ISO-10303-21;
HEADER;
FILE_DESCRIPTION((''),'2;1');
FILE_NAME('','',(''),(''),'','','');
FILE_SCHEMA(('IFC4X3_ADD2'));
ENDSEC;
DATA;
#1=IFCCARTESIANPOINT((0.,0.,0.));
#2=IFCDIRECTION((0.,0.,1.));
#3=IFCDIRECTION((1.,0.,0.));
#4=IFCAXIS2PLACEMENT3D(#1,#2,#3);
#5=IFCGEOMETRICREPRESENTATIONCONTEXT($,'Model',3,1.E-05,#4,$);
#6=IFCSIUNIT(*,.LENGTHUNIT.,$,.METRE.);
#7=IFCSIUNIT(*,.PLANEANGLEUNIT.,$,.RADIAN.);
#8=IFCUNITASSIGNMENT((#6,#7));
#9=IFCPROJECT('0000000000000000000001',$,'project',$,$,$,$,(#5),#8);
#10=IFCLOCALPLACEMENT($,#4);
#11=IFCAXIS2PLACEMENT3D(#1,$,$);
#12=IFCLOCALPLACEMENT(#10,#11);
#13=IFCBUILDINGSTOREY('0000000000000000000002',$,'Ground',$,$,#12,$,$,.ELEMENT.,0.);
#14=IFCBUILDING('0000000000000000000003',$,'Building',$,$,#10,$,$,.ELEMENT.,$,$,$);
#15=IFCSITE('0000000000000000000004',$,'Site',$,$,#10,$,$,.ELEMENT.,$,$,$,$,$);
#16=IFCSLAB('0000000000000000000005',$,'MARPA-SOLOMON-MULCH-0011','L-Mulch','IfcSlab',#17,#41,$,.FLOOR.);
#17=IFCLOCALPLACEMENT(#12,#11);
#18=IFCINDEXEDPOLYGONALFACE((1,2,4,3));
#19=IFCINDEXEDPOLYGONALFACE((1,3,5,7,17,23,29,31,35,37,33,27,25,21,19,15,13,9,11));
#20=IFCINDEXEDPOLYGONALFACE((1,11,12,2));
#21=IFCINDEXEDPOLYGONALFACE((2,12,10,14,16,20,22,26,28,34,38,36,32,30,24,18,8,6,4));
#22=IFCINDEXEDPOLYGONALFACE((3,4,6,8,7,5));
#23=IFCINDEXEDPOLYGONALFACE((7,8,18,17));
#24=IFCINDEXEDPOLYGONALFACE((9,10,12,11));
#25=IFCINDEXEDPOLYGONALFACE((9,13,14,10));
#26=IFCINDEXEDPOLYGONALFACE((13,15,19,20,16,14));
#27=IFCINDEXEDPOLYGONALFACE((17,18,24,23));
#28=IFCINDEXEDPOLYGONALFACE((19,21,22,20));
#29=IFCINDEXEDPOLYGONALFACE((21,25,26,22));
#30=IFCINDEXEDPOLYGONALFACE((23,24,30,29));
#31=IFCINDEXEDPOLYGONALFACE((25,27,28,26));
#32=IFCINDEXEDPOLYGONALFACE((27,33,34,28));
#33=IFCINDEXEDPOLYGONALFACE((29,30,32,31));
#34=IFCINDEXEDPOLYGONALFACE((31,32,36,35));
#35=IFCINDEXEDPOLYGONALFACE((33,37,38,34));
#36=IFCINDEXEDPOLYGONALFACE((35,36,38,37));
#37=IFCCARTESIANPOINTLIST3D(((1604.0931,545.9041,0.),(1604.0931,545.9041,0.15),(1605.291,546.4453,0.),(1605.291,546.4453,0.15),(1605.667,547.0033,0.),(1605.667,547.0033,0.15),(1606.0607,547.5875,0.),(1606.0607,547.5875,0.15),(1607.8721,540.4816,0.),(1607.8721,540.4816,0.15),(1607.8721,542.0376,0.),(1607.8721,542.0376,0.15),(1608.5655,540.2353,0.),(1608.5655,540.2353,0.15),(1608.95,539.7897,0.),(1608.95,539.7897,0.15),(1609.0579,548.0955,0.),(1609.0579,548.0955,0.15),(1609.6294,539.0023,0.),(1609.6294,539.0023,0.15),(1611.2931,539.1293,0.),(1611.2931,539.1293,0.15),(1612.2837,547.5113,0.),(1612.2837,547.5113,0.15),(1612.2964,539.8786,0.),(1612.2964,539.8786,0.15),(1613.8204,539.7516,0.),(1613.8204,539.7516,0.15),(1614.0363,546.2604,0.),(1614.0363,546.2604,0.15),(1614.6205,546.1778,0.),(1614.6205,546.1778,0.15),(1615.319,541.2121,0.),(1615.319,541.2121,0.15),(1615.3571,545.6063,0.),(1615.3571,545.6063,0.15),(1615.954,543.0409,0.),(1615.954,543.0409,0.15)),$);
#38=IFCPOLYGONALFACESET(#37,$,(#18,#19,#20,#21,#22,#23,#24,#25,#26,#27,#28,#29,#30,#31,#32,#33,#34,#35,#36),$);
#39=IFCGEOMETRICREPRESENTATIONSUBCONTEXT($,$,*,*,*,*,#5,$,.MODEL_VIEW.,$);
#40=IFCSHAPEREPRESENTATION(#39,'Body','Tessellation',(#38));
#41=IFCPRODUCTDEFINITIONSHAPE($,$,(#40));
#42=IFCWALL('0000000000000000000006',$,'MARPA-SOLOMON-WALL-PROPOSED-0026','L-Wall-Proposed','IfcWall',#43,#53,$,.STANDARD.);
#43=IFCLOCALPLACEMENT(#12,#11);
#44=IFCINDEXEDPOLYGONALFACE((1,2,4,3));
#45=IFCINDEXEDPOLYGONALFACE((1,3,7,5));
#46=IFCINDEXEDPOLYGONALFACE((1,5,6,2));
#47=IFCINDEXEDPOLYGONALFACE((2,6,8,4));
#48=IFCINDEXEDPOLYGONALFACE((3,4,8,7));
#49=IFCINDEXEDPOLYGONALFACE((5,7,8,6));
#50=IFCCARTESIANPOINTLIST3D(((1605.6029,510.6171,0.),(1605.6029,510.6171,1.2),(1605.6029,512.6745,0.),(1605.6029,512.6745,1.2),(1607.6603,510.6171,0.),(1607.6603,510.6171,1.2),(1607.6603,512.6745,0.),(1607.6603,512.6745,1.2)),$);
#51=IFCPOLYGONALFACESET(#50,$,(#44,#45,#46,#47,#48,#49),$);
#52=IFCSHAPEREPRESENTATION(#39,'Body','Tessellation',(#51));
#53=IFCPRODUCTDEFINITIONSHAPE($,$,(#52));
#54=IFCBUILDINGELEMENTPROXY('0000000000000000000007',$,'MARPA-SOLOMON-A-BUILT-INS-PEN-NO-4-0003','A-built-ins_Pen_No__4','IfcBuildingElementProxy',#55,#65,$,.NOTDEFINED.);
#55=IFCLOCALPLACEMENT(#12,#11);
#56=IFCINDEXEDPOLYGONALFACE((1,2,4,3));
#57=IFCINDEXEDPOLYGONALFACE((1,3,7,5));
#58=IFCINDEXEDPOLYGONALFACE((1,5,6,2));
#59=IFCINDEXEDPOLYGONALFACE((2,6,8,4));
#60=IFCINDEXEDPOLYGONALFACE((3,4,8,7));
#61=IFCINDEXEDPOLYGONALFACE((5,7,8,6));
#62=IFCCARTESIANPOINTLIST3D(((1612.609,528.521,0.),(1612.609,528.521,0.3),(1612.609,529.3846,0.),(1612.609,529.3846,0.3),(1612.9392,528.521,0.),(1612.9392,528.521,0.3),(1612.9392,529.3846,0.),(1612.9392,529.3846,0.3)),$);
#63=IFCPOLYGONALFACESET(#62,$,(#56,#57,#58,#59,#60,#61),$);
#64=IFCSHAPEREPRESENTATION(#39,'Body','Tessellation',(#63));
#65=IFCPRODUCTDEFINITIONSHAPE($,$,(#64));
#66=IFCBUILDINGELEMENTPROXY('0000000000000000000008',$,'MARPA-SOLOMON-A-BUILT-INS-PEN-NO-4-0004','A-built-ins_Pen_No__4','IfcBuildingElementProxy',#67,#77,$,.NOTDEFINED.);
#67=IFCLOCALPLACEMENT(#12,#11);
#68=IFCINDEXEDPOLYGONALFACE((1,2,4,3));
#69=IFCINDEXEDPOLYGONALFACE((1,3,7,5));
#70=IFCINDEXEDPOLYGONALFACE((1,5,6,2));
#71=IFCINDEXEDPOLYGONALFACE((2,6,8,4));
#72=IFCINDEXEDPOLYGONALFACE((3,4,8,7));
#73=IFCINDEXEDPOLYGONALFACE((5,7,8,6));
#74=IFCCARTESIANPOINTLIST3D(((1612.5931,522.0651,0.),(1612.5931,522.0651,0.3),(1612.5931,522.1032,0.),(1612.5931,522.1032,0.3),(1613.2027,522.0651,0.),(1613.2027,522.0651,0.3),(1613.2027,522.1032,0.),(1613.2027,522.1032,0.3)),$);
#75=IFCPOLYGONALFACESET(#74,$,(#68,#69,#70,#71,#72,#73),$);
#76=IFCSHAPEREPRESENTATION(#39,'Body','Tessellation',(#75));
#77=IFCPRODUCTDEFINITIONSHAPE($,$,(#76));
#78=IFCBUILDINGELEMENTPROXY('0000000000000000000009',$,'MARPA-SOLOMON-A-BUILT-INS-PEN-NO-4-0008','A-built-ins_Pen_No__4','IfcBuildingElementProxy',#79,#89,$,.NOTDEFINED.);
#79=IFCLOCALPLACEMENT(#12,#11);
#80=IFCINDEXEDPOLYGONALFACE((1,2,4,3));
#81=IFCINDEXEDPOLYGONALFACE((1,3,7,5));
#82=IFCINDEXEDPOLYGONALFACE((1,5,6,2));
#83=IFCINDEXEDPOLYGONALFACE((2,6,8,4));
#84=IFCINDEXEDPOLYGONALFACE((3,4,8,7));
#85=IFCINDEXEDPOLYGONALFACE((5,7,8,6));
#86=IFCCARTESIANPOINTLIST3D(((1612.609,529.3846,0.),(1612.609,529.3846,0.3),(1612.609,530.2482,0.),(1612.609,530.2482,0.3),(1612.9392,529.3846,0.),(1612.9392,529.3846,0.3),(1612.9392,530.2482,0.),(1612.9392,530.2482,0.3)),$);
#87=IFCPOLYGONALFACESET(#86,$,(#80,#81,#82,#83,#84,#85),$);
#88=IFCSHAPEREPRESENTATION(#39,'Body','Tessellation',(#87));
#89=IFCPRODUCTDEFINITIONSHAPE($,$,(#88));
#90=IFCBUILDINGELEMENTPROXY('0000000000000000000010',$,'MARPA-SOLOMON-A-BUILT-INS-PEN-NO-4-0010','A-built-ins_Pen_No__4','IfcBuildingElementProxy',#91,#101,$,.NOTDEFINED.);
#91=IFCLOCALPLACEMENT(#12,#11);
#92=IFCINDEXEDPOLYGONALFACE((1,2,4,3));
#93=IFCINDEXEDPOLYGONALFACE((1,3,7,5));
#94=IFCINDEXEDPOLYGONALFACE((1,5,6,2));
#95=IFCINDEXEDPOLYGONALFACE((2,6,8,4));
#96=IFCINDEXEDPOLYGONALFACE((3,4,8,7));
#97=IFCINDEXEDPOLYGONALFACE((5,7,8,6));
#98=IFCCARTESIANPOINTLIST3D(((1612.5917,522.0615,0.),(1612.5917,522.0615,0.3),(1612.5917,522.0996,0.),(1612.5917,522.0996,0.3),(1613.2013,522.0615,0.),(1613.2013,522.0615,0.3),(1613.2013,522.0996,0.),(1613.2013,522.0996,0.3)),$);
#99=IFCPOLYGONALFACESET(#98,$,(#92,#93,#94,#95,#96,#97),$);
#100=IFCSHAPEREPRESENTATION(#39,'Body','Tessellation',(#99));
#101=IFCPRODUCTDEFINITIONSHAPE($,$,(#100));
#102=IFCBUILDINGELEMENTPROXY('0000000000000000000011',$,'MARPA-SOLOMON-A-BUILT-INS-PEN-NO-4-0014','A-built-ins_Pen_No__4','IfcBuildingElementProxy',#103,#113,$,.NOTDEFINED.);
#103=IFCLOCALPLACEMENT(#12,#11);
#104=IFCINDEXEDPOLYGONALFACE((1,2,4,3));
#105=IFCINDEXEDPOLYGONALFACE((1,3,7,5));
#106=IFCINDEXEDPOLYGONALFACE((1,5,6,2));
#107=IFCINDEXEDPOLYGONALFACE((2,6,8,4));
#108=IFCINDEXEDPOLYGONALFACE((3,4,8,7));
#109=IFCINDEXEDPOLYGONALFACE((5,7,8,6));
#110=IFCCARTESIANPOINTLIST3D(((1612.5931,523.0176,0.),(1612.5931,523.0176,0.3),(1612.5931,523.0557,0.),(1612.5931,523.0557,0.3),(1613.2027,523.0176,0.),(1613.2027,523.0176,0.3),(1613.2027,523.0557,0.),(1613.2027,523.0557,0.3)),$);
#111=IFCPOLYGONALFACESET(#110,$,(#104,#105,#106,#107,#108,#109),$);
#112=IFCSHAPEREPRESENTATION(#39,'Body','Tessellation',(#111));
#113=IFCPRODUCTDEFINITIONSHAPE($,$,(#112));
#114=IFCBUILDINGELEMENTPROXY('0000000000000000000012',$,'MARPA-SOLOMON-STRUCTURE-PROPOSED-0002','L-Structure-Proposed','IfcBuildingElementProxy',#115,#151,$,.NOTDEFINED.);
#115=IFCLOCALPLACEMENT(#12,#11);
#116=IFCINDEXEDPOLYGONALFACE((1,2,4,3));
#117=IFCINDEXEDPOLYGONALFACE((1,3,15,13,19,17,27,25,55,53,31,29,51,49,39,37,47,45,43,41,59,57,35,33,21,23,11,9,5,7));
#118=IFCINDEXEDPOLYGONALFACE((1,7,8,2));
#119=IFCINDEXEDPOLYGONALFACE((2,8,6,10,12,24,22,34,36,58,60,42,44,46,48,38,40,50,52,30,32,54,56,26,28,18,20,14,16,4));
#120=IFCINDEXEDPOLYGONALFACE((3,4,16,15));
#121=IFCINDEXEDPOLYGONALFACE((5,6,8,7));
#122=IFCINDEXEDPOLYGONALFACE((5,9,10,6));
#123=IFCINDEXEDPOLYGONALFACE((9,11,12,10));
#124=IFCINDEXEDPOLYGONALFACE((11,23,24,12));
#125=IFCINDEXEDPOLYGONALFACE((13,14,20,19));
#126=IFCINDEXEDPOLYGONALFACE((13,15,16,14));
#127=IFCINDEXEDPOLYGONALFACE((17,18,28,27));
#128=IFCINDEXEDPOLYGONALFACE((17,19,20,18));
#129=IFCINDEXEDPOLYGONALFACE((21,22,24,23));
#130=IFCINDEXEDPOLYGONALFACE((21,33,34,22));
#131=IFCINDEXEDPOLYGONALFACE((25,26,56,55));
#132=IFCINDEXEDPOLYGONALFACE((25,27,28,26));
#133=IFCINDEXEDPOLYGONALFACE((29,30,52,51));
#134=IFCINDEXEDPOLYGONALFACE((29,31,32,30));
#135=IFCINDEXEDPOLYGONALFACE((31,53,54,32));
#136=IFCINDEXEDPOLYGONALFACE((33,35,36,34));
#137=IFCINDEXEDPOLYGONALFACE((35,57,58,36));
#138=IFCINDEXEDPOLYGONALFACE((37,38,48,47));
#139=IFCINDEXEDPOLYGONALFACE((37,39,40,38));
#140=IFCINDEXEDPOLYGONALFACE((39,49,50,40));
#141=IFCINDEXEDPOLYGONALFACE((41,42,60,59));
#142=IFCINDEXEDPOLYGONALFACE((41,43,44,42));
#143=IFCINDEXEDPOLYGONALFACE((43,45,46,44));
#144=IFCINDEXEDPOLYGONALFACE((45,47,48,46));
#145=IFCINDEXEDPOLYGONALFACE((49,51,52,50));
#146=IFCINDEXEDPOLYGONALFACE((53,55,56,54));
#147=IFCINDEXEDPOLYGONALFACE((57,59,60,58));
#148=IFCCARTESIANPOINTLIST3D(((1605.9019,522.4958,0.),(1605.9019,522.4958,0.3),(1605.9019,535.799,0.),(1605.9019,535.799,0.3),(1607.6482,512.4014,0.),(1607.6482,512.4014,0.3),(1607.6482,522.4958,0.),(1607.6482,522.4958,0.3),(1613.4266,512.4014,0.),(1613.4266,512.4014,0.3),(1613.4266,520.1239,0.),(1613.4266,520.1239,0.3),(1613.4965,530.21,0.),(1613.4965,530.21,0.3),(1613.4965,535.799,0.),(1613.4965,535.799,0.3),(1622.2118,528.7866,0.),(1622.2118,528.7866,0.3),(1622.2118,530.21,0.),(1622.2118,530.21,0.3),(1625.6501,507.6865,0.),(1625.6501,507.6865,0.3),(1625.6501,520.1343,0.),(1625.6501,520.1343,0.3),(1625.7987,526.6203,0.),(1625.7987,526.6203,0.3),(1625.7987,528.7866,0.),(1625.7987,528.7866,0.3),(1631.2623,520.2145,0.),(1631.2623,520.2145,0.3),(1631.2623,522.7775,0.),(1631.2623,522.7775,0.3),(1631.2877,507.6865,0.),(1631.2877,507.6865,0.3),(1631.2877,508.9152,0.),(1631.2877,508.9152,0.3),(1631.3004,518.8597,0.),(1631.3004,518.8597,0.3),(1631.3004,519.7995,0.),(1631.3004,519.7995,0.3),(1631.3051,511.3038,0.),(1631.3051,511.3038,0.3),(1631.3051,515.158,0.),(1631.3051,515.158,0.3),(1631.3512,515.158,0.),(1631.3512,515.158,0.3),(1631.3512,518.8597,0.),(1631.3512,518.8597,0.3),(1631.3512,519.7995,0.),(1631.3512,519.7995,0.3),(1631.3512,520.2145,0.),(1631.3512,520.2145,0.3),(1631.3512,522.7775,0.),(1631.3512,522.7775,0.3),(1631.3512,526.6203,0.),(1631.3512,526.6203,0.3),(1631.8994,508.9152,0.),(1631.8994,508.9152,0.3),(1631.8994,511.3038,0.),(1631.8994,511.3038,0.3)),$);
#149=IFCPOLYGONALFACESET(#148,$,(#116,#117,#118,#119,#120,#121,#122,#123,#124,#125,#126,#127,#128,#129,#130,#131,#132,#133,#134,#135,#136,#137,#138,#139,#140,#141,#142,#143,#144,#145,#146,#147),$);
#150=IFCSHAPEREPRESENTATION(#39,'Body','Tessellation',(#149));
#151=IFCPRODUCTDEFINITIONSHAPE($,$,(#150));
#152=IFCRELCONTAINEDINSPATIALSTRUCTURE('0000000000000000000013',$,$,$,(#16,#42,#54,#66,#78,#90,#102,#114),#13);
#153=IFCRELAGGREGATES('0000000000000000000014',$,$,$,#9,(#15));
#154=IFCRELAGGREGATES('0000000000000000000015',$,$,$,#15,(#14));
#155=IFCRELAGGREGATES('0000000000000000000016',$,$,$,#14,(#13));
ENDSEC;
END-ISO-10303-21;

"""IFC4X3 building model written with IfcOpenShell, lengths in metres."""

from ifc_helpers import new_model, si_unit, frame, frame_2d, origin, origin_with_axes, place, context, subcontext, project, spatial, polyline, rectangle, outline, extrude, element, save


model = new_model("IFC4X3")

# Units and contexts
model_context = context("Model", 3, precision=1e-05, world=origin_with_axes())
sub_context = subcontext(model_context, None, None, "MODEL_VIEW")
ifc_project = project(units=[si_unit("LENGTHUNIT", "METRE"), si_unit("PLANEANGLEUNIT", "RADIAN")], contexts=[model_context])

# Site, building, storey
placement = place(None, origin_with_axes())
site = spatial("IfcSite", under=ifc_project, at=placement, Name="Site", CompositionType="ELEMENT")
building = spatial("IfcBuilding", under=site, at=placement, Name="Building", CompositionType="ELEMENT")
storey_placement = place(placement, origin())
storey = spatial("IfcBuildingStorey", under=building, at=storey_placement, Name="Ground", CompositionType="ELEMENT", Elevation=0.0)

# Slab
slab_1_placement = place(storey_placement, frame((1604.0931, 539.0023, 0.0)))
element("IfcSlab", 1, at=slab_1_placement, inside=storey, Name="MARPA-SOLOMON-MULCH-0011", Description="L-Mulch", ObjectType="IfcSlab", PredefinedType="FLOOR", context=sub_context, shape_type="SweptSolid", body=[
    extrude(outline(polyline([(1.9676, 8.5852), (1.5739, 8.001), (1.1979, 7.443), (0.0, 6.9017), (3.779, 3.0353), (3.779, 1.4792), (4.4724, 1.2329), (4.8569, 0.7874), (5.5363, 0.0), (7.2, 0.127), (8.2033, 0.8763), (9.7273, 0.7493), (11.2259, 2.2098), (11.8609, 4.0386), (11.264, 6.604), (10.5274, 7.1755), (9.9432, 7.2581), (8.1906, 8.509), (4.9648, 9.0932), (1.9676, 8.5852)])), origin(), (0.0, 0.0, 1.0), 0.15),
])

# Wall
wall_placement = place(storey_placement, frame((1606.6316, 510.6171, 0.0), x_axis=(0.0, 1.0, 0.0)))
element("IfcWall", 2, at=wall_placement, inside=storey, Name="MARPA-SOLOMON-WALL-PROPOSED-0026", Description="L-Wall-Proposed", ObjectType="IfcWall", PredefinedType="STANDARD", context=sub_context, shape_type="SweptSolid", body=[
    extrude(rectangle(XDim=2.0574, YDim=2.0574, at=frame_2d((1.0287, 0.0))), origin(), (0.0, 0.0, 1.0), 1.2),
])

# Building element proxies
proxy_1_placement = place(placement, frame((1612.609, 528.521, 0.0)))
element("IfcBuildingElementProxy", 3, at=proxy_1_placement, inside=storey, Name="MARPA-SOLOMON-A-BUILT-INS-PEN-NO-4-0003", Description="A-built-ins_Pen_No__4", ObjectType="IfcBuildingElementProxy", PredefinedType="NOTDEFINED", context=sub_context, shape_type="SweptSolid", body=[
    extrude(outline(polyline([(0.3302, 0.8636), (0.3302, 0.0), (0.0, 0.0), (0.0, 0.8636), (0.3302, 0.8636)])), origin(), (0.0, 0.0, 1.0), 0.3),
])
proxy_2_placement = place(placement, frame((1612.5931, 522.0651, 0.0)))
element("IfcBuildingElementProxy", 4, at=proxy_2_placement, inside=storey, Name="MARPA-SOLOMON-A-BUILT-INS-PEN-NO-4-0004", Description="A-built-ins_Pen_No__4", ObjectType="IfcBuildingElementProxy", PredefinedType="NOTDEFINED", context=sub_context, shape_type="SweptSolid", body=[
    extrude(outline(polyline([(0.6096, 0.0381), (0.6096, 0.0), (0.0, 0.0), (0.0, 0.0381), (0.6096, 0.0381)])), origin(), (0.0, 0.0, 1.0), 0.3),
])
proxy_3_placement = place(placement, frame((1612.609, 529.3846, 0.0)))
element("IfcBuildingElementProxy", 5, at=proxy_3_placement, inside=storey, Name="MARPA-SOLOMON-A-BUILT-INS-PEN-NO-4-0008", Description="A-built-ins_Pen_No__4", ObjectType="IfcBuildingElementProxy", PredefinedType="NOTDEFINED", context=sub_context, shape_type="SweptSolid", body=[
    extrude(outline(polyline([(0.3302, 0.8636), (0.3302, 0.0), (0.0, 0.0), (0.0, 0.8636), (0.3302, 0.8636)])), origin(), (0.0, 0.0, 1.0), 0.3),
])
for number, where, name in (
    (6, (1612.5917, 522.0615, 0.0), "MARPA-SOLOMON-A-BUILT-INS-PEN-NO-4-0010"),
    (7, (1612.5931, 523.0176, 0.0), "MARPA-SOLOMON-A-BUILT-INS-PEN-NO-4-0014"),
):
    element("IfcBuildingElementProxy", number, at=place(placement, frame(where)), inside=storey, Name=name, Description="A-built-ins_Pen_No__4", ObjectType="IfcBuildingElementProxy", PredefinedType="NOTDEFINED", context=sub_context, shape_type="SweptSolid", body=[
        extrude(outline(polyline([(0.6096, 0.0381), (0.6096, 0.0), (0.0, 0.0), (0.0, 0.0381), (0.6096, 0.0381)])), origin(), (0.0, 0.0, 1.0), 0.3),
    ])
proxy_4_placement = place(placement, frame((1605.9019, 507.6865, 0.0)))
element("IfcBuildingElementProxy", 8, at=proxy_4_placement, inside=storey, Name="MARPA-SOLOMON-STRUCTURE-PROPOSED-0002", Description="L-Structure-Proposed", ObjectType="IfcBuildingElementProxy", PredefinedType="NOTDEFINED", context=sub_context, shape_type="SweptSolid", body=[
    extrude(outline(polyline([(16.3098, 22.5235), (16.3098, 21.1002), (19.8967, 21.1002), (19.8967, 18.9339), (25.4493, 18.9339), (25.4493, 15.0911), (25.3604, 15.0911), (25.3604, 12.528), (25.4493, 12.528), (25.4493, 12.113), (25.3985, 12.113), (25.3985, 11.1732), (25.4493, 11.1732), (25.4493, 7.4715), (25.4032, 7.4715), (25.4032, 3.6173), (25.9974, 3.6173), (25.9974, 1.2287), (25.3858, 1.2287), (25.3858, 0.0), (19.7481, 0.0), (19.7481, 12.4478), (7.5247, 12.4375), (7.5247, 4.7149), (1.7462, 4.7149), (1.7462, 14.8093), (0.0, 14.8093), (0.0, 28.1125), (7.5946, 28.1125), (7.5946, 22.5235), (16.3098, 22.5235)])), origin(), (0.0, 0.0, 1.0), 0.3),
])

save(model, "model.ifc")
